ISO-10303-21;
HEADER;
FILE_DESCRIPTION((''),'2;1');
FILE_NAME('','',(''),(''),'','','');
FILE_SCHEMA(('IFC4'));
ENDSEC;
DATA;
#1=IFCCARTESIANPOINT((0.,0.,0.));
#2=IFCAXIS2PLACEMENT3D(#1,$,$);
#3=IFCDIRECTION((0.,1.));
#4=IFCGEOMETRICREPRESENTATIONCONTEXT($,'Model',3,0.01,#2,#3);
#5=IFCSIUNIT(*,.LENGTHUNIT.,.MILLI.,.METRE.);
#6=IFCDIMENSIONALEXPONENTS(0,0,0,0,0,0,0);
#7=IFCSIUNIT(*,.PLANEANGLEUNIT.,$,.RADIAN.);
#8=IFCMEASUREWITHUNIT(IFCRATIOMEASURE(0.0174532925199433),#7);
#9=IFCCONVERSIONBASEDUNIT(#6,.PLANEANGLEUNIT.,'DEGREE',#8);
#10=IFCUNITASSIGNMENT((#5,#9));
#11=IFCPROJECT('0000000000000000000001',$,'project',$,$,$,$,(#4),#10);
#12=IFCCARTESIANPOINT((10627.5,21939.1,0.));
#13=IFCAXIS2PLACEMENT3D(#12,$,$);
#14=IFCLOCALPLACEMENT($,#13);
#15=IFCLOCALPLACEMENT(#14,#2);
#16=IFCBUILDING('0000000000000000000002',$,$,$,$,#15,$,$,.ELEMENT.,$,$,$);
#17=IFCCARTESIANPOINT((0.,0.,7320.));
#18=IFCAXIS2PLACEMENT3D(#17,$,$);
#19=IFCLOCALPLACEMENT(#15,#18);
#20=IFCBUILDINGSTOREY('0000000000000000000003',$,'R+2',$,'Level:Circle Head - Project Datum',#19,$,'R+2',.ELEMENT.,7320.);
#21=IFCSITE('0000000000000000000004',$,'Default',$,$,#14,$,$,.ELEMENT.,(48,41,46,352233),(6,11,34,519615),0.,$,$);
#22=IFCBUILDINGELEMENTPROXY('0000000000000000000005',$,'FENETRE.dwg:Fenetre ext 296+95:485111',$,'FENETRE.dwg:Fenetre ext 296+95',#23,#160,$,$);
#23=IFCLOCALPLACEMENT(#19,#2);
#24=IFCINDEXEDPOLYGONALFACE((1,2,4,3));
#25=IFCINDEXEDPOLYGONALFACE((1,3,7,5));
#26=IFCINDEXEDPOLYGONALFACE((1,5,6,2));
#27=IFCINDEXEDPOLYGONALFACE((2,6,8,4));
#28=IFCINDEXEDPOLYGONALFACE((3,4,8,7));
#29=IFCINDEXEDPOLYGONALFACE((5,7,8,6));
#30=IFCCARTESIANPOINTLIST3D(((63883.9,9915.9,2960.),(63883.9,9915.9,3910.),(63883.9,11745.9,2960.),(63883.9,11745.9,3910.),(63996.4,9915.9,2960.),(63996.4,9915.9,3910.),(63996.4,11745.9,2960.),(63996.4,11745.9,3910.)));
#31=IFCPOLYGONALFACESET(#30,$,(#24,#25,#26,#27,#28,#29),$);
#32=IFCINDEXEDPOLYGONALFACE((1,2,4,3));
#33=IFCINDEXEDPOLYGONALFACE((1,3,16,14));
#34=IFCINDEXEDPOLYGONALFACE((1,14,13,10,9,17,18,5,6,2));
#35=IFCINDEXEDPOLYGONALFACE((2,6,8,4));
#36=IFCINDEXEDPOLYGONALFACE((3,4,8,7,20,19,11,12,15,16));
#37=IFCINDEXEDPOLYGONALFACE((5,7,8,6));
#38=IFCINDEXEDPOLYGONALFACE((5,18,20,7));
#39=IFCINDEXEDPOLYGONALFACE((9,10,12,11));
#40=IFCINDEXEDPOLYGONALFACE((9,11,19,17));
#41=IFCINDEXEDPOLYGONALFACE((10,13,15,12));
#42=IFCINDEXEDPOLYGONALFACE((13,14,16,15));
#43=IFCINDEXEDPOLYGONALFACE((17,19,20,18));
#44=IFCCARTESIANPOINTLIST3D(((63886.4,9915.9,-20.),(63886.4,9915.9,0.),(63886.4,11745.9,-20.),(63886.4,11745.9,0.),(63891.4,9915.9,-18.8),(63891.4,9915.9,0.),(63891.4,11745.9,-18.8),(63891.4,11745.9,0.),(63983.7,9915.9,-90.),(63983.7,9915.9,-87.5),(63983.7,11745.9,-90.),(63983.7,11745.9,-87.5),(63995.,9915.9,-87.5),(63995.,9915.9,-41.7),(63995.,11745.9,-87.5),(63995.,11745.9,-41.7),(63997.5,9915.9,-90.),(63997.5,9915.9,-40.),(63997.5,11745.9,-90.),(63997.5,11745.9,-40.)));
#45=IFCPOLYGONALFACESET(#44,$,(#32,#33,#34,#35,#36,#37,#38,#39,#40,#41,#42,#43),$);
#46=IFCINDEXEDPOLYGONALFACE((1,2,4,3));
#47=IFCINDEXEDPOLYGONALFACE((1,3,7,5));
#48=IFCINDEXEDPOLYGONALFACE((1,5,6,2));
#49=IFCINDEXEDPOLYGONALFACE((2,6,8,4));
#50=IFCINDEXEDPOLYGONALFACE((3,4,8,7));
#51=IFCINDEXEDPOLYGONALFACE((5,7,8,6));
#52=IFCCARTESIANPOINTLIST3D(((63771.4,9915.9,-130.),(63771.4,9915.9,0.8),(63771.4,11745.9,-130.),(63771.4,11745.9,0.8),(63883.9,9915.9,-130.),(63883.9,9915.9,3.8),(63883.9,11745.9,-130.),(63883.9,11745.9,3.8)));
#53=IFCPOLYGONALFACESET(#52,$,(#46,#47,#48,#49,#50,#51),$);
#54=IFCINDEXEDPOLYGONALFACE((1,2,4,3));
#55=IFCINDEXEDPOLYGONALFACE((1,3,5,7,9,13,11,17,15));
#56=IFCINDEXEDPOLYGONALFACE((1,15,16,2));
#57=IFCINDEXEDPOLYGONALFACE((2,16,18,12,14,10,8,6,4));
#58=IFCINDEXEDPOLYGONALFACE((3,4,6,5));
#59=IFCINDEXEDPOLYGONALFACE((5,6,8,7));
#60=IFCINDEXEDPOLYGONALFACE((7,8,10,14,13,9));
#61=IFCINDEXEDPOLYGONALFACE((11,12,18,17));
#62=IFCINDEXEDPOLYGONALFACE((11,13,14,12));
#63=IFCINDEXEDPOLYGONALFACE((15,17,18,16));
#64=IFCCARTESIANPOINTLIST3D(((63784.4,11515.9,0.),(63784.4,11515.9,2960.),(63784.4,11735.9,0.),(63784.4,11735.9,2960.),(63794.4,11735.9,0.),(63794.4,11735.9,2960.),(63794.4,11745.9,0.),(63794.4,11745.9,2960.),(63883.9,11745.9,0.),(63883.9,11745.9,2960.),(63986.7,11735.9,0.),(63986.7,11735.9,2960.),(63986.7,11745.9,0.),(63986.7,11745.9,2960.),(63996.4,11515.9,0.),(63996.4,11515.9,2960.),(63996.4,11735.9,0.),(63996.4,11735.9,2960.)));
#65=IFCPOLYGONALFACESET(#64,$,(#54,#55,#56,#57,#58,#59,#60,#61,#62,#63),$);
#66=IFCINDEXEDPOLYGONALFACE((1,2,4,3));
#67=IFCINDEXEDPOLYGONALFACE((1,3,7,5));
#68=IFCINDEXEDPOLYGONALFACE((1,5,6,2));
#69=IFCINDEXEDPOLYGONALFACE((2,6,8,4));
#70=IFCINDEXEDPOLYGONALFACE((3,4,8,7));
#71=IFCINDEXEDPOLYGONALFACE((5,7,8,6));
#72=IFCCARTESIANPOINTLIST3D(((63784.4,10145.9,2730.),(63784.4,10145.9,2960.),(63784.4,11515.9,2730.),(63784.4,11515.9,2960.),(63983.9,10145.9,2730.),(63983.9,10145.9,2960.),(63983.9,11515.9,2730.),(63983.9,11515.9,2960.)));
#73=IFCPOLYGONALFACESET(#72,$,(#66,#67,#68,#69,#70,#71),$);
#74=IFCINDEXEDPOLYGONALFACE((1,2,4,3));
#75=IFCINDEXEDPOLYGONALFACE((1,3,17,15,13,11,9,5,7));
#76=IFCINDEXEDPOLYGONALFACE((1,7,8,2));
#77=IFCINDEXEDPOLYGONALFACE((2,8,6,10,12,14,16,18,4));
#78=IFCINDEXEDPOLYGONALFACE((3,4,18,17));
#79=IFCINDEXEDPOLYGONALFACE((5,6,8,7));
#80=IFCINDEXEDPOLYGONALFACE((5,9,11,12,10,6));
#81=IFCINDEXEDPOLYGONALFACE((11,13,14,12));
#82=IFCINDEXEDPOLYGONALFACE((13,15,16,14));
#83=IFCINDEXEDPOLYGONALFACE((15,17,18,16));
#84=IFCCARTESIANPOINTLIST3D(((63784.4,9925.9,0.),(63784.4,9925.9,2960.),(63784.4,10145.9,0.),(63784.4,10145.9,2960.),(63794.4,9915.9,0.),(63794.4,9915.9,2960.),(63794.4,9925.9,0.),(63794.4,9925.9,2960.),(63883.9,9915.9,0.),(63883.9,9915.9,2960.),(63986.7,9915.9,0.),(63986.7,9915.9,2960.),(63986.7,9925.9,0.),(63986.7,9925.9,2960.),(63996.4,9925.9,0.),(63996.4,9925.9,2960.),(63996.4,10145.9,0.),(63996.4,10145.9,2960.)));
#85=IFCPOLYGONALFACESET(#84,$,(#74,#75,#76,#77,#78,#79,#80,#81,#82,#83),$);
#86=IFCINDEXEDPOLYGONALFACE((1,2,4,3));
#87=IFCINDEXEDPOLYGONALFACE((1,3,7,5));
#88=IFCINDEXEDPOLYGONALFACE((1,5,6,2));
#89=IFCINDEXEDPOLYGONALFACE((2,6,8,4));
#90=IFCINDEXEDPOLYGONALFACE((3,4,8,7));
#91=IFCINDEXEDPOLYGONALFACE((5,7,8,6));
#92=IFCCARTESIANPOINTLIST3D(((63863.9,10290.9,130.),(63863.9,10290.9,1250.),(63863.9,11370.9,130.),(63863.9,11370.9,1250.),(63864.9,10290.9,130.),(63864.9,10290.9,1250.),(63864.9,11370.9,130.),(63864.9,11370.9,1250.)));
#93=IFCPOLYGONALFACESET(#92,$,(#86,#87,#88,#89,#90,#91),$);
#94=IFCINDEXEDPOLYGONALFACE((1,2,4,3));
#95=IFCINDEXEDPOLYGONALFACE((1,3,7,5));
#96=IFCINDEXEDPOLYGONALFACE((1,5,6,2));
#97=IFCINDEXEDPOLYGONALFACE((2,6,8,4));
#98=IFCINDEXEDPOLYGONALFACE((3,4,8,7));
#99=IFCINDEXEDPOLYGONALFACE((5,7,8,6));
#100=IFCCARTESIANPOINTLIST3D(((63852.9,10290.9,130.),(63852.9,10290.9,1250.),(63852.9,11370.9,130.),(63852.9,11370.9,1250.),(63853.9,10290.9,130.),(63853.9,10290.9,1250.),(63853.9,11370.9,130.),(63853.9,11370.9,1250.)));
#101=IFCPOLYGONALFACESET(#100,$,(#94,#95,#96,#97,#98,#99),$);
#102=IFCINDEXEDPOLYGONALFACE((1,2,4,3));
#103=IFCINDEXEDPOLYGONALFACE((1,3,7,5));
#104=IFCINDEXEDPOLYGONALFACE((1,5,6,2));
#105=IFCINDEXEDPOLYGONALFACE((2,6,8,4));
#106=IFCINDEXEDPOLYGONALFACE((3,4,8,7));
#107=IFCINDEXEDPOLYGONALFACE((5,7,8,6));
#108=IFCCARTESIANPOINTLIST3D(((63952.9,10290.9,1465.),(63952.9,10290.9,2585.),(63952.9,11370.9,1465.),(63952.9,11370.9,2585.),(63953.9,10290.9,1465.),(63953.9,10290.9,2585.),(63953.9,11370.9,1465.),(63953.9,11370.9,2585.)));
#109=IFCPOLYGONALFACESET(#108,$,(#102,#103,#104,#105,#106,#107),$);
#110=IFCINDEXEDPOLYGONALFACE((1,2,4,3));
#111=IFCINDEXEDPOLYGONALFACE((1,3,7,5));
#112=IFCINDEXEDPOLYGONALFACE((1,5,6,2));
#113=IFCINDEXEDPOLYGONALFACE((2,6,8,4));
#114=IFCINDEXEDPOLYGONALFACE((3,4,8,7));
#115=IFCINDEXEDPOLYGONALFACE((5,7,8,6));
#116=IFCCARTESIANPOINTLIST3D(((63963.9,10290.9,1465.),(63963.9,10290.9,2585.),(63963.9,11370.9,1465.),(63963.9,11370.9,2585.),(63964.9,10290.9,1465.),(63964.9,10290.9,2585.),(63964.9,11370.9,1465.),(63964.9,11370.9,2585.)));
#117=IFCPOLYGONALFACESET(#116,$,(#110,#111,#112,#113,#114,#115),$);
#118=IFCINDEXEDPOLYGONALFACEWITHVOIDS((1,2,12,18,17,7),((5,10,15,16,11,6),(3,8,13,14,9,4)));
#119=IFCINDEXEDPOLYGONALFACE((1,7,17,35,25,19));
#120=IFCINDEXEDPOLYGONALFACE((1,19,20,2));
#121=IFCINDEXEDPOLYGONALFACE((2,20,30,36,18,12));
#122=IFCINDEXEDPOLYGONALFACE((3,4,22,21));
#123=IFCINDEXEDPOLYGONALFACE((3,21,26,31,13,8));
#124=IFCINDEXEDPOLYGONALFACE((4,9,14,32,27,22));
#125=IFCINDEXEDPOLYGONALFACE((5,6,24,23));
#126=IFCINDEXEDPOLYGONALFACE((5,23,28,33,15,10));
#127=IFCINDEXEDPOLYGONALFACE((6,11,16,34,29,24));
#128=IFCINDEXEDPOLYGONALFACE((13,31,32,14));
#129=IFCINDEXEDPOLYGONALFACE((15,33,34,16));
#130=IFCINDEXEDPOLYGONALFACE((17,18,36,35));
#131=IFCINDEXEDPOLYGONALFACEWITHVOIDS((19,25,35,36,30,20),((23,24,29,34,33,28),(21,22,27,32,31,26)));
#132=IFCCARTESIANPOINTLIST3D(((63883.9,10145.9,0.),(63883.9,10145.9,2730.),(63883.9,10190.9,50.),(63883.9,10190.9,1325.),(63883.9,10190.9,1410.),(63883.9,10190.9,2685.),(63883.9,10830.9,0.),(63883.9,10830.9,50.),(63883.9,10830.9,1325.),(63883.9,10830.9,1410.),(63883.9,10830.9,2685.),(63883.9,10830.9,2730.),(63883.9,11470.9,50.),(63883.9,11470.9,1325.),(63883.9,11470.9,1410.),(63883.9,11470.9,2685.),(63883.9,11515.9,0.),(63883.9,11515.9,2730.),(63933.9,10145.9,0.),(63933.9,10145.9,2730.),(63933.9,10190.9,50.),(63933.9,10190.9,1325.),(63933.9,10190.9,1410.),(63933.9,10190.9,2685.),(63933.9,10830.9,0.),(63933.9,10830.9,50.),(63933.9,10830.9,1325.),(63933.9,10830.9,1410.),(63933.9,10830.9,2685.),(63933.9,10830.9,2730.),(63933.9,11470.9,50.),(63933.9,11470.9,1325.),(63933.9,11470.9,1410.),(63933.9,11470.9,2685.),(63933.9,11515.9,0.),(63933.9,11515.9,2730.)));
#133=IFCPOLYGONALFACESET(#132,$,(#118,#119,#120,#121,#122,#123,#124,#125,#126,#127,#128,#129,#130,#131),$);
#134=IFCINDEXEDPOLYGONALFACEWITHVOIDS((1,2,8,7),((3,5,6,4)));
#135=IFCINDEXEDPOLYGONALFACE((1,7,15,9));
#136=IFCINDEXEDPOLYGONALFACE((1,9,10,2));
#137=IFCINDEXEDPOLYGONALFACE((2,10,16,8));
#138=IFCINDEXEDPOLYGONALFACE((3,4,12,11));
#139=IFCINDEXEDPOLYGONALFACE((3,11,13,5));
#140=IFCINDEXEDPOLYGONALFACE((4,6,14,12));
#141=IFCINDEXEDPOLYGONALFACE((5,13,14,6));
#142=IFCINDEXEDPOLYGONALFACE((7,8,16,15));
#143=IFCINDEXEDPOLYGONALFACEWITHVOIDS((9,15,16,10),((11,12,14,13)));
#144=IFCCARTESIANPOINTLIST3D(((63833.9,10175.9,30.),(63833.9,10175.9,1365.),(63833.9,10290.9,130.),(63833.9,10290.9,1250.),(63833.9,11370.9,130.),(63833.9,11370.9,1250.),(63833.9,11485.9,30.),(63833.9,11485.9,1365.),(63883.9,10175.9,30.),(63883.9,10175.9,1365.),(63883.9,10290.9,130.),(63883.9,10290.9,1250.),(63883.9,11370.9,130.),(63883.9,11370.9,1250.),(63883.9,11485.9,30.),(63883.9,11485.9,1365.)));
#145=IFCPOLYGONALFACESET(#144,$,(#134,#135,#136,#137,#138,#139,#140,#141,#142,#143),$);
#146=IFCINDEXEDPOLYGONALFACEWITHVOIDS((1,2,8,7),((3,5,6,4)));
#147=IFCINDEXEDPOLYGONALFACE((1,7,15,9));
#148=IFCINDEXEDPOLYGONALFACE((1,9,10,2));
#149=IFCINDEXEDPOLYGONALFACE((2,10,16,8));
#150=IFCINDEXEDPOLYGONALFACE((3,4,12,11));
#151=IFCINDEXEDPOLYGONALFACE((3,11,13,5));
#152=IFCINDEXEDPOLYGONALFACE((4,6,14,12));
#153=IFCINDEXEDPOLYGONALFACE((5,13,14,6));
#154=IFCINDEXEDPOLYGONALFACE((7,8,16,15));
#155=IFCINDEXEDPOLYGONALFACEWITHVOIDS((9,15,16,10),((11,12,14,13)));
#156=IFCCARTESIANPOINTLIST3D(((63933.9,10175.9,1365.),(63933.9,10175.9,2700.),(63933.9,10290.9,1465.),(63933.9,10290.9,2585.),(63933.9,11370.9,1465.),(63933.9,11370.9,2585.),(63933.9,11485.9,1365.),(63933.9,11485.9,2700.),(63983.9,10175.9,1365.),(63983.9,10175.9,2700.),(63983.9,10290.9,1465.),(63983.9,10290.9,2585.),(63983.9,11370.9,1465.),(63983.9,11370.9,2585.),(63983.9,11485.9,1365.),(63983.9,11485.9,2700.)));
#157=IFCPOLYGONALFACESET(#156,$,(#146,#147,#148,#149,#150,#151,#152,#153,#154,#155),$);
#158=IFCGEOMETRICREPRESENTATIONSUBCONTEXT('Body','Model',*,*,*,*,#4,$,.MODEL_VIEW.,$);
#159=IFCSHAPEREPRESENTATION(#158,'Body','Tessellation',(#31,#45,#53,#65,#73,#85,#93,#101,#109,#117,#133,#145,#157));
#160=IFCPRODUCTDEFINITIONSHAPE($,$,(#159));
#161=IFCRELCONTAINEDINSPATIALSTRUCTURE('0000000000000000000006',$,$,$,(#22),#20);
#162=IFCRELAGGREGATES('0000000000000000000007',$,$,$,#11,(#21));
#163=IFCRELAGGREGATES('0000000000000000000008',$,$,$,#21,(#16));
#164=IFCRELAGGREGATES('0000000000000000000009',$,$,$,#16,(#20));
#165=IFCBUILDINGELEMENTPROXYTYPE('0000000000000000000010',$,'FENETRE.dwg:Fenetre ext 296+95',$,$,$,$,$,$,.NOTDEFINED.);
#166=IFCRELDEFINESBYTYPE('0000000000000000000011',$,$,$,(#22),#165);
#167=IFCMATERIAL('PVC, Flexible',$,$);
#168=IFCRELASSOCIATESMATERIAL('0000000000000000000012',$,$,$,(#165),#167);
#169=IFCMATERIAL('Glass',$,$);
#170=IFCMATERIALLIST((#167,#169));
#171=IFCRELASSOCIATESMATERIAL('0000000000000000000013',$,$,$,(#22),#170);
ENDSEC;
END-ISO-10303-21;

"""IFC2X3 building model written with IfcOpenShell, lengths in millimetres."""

from ifc_helpers import new_model, entity, si_unit, converted_unit, direction, frame, frame_2d, origin, origin_2d_with_axis, place, context, subcontext, project, spatial, polyline, rectangle, outline, extrude, source, transform, mapped, material, material_list, type_object, type_shapes, element, save


model = new_model("IFC2X3")

# Units and contexts
model_context = context("Model", 3, precision=0.01, world=origin(), true_north=direction((0.0, 1.0)))
body_context = subcontext(model_context, "Body", "Model", "MODEL_VIEW")
ifc_project = project(units=[si_unit("LENGTHUNIT", "METRE", prefix="MILLI"), converted_unit("PLANEANGLEUNIT", "DEGREE", entity("IfcRatioMeasure", 0.0174532925199433), si_unit("PLANEANGLEUNIT", "RADIAN"), dimensions=[0, 0, 0, 0, 0, 0, 0])], contexts=[model_context])

# Site, building, storey
site_placement = place(None, frame((10627.5, 21939.1, 0.0)))
site = spatial("IfcSite", under=ifc_project, at=site_placement, Name="Default", CompositionType="ELEMENT", RefLatitude=(48, 41, 46, 352233), RefLongitude=(6, 11, 34, 519615), RefElevation=0.0)
building_placement = place(site_placement, origin())
building = spatial("IfcBuilding", under=site, at=building_placement, CompositionType="ELEMENT")
storey_placement = place(building_placement, frame((0.0, 0.0, 7320.0)))
storey = spatial("IfcBuildingStorey", under=building, at=storey_placement, Name="R+2", ObjectType="Level:Circle Head - Project Datum", LongName="R+2", CompositionType="ELEMENT", Elevation=7320.0)

# Building element proxy
ifc_material_1 = material(Name="PVC, Flexible")
ifc_material_2 = material(Name="Glass")
building_element_proxy_type_1 = type_object("IfcBuildingElementProxyType", Name="FENETRE.dwg:Fenetre ext 296+95", PredefinedType="NOTDEFINED", material=ifc_material_1)
shared_shape_1 = source(origin(), body_context, "Body", "SweptSolid", [
    extrude(rectangle(XDim=112.5, YDim=1830.0, at=origin_2d_with_axis()), frame((-10.4, -56.3, 2960.0), z_axis=(0.0, 0.0, 1.0), x_axis=(0.0, 1.0, 0.0)), (0.0, 0.0, 1.0), 950.0),
    extrude(outline(polyline([(27.5, -64.4), (47.5, -64.4), (47.5, -59.4), (28.8, -59.4), (7.5, 46.7), (-42.5, 46.7), (-42.5, 32.9), (-40.0, 32.9), (-40.0, 44.2), (5.8, 44.2), (27.5, -64.4)])), frame((-925.4, -66.9, -47.5), z_axis=(1.0, 0.0, 0.0), x_axis=(0.0, 0.0, 1.0)), (0.0, 0.0, 1.0), 1830.0),
    extrude(outline(polyline([(-54.5, -66.1), (58.0, -66.1), (54.5, 67.6), (-58.0, 64.6), (-54.5, -66.1)])), frame((-925.4, 56.3, -63.8), z_axis=(1.0, 0.0, 0.0), x_axis=(0.0, -0.999645, 0.02665)), (0.0, 0.0, 1.0), 1830.0),
    extrude(outline(polyline([(-97.0, -55.6), (5.9, -55.6), (95.4, -55.6), (95.4, -45.6), (105.4, -45.6), (105.4, 174.4), (-106.6, 174.4), (-106.6, -45.6), (-97.0, -45.6), (-97.0, -55.6)])), frame((849.0, -5.9, 0.0), z_axis=(0.0, 0.0, 1.0), x_axis=(0.0, 1.0, 0.0)), (0.0, 0.0, 1.0), 2960.0),
    extrude(rectangle(XDim=1370.0, YDim=199.5, at=origin_2d_with_axis()), frame((-10.4, -0.3, 2730.0), z_axis=(0.0, 0.0, 1.0), x_axis=(-1.0, 0.0, 0.0)), (0.0, 0.0, 1.0), 230.0),
    extrude(outline(polyline([(-55.6, 97.0), (-55.6, -5.9), (-55.6, -95.4), (-45.6, -95.4), (-45.6, -105.4), (174.4, -105.4), (174.4, 106.6), (-45.6, 106.6), (-45.6, 97.0), (-55.6, 97.0)])), frame((-869.9, -5.9, 0.0), z_axis=(0.0, 0.0, -1.0), x_axis=(1.0, 0.0, 0.0)), (0.0, 0.0, -1.0), 2960.0),
    extrude(rectangle(XDim=1080.0, YDim=1.0, at=origin_2d_with_axis()), frame((-10.4, 19.5, 130.0), z_axis=(0.0, 0.0, 1.0), x_axis=(-1.0, 0.0, 0.0)), (0.0, 0.0, 1.0), 1120.0),
    extrude(rectangle(XDim=1080.0, YDim=1.0, at=origin_2d_with_axis()), frame((-10.4, 30.5, 130.0), z_axis=(0.0, 0.0, 1.0), x_axis=(-1.0, 0.0, 0.0)), (0.0, 0.0, 1.0), 1120.0),
    extrude(rectangle(XDim=1080.0, YDim=1.0, at=frame_2d((0.0, 0.0), x_axis=(1.0, 0.0))), frame((-10.4, -69.5, 1465.0), z_axis=(0.0, 0.0, 1.0), x_axis=(-1.0, 0.0, 0.0)), (0.0, 0.0, 1.0), 1120.0),
    extrude(rectangle(XDim=1080.0, YDim=1.0, at=frame_2d((0.0, 0.0), x_axis=(1.0, 0.0))), frame((-10.4, -80.5, 1465.0), z_axis=(0.0, 0.0, 1.0), x_axis=(-1.0, 0.0, 0.0)), (0.0, 0.0, 1.0), 1120.0),
    extrude(outline(polyline([(-685.0, -1365.0), (0.0, -1365.0), (685.0, -1365.0), (685.0, 1365.0), (0.0, 1365.0), (-685.0, 1365.0), (-685.0, -1365.0)]), holes=[polyline([(-640.0, -1320.0), (-640.0, -45.0), (0.0, -45.0), (640.0, -45.0), (640.0, -1320.0), (0.0, -1320.0), (-640.0, -1320.0)]), polyline([(-640.0, 40.0), (-640.0, 1315.0), (0.0, 1315.0), (640.0, 1315.0), (640.0, 40.0), (0.0, 40.0), (-640.0, 40.0)])]), frame((-10.4, -50.0, 1365.0), z_axis=(0.0, 1.0, 0.0), x_axis=(1.0, 0.0, 0.0)), (0.0, 0.0, 1.0), 50.0),
    extrude(outline(polyline([(-655.0, -667.5), (655.0, -667.5), (655.0, 667.5), (-655.0, 667.5), (-655.0, -667.5)]), holes=[polyline([(-540.0, 552.5), (540.0, 552.5), (540.0, -567.5), (-540.0, -567.5), (-540.0, 552.5)])]), frame((-10.4, 0.0, 697.5), z_axis=(0.0, 1.0, 0.0), x_axis=(-1.0, 0.0, 0.0)), (0.0, 0.0, 1.0), 50.0),
    extrude(outline(polyline([(-655.0, -667.5), (655.0, -667.5), (655.0, 667.5), (-655.0, 667.5), (-655.0, -667.5)]), holes=[polyline([(-540.0, 552.5), (540.0, 552.5), (540.0, -567.5), (-540.0, -567.5), (-540.0, 552.5)])]), frame((-10.4, -100.0, 2032.5), z_axis=(0.0, 1.0, 0.0), x_axis=(-1.0, 0.0, 0.0)), (0.0, 0.0, 1.0), 50.0),
])
type_shapes(building_element_proxy_type_1, [shared_shape_1])
ifc_material_list_1 = material_list([ifc_material_1, ifc_material_2])
proxy_1_placement = place(storey_placement, frame((63883.9, 10841.3, 0.0), z_axis=(0.0, 0.0, 1.0), x_axis=(0.0, 1.0, 0.0)))
element("IfcBuildingElementProxy", 1, at=proxy_1_placement, inside=storey, type_object=building_element_proxy_type_1, material=ifc_material_list_1, Name="FENETRE.dwg:Fenetre ext 296+95:485111", ObjectType="FENETRE.dwg:Fenetre ext 296+95", context=body_context, shape_type="MappedRepresentation", body=[
    mapped(shared_shape_1, transform((0.0, 0.0, 0.0), scale=1.0)),
])

save(model, "model.ifc")
